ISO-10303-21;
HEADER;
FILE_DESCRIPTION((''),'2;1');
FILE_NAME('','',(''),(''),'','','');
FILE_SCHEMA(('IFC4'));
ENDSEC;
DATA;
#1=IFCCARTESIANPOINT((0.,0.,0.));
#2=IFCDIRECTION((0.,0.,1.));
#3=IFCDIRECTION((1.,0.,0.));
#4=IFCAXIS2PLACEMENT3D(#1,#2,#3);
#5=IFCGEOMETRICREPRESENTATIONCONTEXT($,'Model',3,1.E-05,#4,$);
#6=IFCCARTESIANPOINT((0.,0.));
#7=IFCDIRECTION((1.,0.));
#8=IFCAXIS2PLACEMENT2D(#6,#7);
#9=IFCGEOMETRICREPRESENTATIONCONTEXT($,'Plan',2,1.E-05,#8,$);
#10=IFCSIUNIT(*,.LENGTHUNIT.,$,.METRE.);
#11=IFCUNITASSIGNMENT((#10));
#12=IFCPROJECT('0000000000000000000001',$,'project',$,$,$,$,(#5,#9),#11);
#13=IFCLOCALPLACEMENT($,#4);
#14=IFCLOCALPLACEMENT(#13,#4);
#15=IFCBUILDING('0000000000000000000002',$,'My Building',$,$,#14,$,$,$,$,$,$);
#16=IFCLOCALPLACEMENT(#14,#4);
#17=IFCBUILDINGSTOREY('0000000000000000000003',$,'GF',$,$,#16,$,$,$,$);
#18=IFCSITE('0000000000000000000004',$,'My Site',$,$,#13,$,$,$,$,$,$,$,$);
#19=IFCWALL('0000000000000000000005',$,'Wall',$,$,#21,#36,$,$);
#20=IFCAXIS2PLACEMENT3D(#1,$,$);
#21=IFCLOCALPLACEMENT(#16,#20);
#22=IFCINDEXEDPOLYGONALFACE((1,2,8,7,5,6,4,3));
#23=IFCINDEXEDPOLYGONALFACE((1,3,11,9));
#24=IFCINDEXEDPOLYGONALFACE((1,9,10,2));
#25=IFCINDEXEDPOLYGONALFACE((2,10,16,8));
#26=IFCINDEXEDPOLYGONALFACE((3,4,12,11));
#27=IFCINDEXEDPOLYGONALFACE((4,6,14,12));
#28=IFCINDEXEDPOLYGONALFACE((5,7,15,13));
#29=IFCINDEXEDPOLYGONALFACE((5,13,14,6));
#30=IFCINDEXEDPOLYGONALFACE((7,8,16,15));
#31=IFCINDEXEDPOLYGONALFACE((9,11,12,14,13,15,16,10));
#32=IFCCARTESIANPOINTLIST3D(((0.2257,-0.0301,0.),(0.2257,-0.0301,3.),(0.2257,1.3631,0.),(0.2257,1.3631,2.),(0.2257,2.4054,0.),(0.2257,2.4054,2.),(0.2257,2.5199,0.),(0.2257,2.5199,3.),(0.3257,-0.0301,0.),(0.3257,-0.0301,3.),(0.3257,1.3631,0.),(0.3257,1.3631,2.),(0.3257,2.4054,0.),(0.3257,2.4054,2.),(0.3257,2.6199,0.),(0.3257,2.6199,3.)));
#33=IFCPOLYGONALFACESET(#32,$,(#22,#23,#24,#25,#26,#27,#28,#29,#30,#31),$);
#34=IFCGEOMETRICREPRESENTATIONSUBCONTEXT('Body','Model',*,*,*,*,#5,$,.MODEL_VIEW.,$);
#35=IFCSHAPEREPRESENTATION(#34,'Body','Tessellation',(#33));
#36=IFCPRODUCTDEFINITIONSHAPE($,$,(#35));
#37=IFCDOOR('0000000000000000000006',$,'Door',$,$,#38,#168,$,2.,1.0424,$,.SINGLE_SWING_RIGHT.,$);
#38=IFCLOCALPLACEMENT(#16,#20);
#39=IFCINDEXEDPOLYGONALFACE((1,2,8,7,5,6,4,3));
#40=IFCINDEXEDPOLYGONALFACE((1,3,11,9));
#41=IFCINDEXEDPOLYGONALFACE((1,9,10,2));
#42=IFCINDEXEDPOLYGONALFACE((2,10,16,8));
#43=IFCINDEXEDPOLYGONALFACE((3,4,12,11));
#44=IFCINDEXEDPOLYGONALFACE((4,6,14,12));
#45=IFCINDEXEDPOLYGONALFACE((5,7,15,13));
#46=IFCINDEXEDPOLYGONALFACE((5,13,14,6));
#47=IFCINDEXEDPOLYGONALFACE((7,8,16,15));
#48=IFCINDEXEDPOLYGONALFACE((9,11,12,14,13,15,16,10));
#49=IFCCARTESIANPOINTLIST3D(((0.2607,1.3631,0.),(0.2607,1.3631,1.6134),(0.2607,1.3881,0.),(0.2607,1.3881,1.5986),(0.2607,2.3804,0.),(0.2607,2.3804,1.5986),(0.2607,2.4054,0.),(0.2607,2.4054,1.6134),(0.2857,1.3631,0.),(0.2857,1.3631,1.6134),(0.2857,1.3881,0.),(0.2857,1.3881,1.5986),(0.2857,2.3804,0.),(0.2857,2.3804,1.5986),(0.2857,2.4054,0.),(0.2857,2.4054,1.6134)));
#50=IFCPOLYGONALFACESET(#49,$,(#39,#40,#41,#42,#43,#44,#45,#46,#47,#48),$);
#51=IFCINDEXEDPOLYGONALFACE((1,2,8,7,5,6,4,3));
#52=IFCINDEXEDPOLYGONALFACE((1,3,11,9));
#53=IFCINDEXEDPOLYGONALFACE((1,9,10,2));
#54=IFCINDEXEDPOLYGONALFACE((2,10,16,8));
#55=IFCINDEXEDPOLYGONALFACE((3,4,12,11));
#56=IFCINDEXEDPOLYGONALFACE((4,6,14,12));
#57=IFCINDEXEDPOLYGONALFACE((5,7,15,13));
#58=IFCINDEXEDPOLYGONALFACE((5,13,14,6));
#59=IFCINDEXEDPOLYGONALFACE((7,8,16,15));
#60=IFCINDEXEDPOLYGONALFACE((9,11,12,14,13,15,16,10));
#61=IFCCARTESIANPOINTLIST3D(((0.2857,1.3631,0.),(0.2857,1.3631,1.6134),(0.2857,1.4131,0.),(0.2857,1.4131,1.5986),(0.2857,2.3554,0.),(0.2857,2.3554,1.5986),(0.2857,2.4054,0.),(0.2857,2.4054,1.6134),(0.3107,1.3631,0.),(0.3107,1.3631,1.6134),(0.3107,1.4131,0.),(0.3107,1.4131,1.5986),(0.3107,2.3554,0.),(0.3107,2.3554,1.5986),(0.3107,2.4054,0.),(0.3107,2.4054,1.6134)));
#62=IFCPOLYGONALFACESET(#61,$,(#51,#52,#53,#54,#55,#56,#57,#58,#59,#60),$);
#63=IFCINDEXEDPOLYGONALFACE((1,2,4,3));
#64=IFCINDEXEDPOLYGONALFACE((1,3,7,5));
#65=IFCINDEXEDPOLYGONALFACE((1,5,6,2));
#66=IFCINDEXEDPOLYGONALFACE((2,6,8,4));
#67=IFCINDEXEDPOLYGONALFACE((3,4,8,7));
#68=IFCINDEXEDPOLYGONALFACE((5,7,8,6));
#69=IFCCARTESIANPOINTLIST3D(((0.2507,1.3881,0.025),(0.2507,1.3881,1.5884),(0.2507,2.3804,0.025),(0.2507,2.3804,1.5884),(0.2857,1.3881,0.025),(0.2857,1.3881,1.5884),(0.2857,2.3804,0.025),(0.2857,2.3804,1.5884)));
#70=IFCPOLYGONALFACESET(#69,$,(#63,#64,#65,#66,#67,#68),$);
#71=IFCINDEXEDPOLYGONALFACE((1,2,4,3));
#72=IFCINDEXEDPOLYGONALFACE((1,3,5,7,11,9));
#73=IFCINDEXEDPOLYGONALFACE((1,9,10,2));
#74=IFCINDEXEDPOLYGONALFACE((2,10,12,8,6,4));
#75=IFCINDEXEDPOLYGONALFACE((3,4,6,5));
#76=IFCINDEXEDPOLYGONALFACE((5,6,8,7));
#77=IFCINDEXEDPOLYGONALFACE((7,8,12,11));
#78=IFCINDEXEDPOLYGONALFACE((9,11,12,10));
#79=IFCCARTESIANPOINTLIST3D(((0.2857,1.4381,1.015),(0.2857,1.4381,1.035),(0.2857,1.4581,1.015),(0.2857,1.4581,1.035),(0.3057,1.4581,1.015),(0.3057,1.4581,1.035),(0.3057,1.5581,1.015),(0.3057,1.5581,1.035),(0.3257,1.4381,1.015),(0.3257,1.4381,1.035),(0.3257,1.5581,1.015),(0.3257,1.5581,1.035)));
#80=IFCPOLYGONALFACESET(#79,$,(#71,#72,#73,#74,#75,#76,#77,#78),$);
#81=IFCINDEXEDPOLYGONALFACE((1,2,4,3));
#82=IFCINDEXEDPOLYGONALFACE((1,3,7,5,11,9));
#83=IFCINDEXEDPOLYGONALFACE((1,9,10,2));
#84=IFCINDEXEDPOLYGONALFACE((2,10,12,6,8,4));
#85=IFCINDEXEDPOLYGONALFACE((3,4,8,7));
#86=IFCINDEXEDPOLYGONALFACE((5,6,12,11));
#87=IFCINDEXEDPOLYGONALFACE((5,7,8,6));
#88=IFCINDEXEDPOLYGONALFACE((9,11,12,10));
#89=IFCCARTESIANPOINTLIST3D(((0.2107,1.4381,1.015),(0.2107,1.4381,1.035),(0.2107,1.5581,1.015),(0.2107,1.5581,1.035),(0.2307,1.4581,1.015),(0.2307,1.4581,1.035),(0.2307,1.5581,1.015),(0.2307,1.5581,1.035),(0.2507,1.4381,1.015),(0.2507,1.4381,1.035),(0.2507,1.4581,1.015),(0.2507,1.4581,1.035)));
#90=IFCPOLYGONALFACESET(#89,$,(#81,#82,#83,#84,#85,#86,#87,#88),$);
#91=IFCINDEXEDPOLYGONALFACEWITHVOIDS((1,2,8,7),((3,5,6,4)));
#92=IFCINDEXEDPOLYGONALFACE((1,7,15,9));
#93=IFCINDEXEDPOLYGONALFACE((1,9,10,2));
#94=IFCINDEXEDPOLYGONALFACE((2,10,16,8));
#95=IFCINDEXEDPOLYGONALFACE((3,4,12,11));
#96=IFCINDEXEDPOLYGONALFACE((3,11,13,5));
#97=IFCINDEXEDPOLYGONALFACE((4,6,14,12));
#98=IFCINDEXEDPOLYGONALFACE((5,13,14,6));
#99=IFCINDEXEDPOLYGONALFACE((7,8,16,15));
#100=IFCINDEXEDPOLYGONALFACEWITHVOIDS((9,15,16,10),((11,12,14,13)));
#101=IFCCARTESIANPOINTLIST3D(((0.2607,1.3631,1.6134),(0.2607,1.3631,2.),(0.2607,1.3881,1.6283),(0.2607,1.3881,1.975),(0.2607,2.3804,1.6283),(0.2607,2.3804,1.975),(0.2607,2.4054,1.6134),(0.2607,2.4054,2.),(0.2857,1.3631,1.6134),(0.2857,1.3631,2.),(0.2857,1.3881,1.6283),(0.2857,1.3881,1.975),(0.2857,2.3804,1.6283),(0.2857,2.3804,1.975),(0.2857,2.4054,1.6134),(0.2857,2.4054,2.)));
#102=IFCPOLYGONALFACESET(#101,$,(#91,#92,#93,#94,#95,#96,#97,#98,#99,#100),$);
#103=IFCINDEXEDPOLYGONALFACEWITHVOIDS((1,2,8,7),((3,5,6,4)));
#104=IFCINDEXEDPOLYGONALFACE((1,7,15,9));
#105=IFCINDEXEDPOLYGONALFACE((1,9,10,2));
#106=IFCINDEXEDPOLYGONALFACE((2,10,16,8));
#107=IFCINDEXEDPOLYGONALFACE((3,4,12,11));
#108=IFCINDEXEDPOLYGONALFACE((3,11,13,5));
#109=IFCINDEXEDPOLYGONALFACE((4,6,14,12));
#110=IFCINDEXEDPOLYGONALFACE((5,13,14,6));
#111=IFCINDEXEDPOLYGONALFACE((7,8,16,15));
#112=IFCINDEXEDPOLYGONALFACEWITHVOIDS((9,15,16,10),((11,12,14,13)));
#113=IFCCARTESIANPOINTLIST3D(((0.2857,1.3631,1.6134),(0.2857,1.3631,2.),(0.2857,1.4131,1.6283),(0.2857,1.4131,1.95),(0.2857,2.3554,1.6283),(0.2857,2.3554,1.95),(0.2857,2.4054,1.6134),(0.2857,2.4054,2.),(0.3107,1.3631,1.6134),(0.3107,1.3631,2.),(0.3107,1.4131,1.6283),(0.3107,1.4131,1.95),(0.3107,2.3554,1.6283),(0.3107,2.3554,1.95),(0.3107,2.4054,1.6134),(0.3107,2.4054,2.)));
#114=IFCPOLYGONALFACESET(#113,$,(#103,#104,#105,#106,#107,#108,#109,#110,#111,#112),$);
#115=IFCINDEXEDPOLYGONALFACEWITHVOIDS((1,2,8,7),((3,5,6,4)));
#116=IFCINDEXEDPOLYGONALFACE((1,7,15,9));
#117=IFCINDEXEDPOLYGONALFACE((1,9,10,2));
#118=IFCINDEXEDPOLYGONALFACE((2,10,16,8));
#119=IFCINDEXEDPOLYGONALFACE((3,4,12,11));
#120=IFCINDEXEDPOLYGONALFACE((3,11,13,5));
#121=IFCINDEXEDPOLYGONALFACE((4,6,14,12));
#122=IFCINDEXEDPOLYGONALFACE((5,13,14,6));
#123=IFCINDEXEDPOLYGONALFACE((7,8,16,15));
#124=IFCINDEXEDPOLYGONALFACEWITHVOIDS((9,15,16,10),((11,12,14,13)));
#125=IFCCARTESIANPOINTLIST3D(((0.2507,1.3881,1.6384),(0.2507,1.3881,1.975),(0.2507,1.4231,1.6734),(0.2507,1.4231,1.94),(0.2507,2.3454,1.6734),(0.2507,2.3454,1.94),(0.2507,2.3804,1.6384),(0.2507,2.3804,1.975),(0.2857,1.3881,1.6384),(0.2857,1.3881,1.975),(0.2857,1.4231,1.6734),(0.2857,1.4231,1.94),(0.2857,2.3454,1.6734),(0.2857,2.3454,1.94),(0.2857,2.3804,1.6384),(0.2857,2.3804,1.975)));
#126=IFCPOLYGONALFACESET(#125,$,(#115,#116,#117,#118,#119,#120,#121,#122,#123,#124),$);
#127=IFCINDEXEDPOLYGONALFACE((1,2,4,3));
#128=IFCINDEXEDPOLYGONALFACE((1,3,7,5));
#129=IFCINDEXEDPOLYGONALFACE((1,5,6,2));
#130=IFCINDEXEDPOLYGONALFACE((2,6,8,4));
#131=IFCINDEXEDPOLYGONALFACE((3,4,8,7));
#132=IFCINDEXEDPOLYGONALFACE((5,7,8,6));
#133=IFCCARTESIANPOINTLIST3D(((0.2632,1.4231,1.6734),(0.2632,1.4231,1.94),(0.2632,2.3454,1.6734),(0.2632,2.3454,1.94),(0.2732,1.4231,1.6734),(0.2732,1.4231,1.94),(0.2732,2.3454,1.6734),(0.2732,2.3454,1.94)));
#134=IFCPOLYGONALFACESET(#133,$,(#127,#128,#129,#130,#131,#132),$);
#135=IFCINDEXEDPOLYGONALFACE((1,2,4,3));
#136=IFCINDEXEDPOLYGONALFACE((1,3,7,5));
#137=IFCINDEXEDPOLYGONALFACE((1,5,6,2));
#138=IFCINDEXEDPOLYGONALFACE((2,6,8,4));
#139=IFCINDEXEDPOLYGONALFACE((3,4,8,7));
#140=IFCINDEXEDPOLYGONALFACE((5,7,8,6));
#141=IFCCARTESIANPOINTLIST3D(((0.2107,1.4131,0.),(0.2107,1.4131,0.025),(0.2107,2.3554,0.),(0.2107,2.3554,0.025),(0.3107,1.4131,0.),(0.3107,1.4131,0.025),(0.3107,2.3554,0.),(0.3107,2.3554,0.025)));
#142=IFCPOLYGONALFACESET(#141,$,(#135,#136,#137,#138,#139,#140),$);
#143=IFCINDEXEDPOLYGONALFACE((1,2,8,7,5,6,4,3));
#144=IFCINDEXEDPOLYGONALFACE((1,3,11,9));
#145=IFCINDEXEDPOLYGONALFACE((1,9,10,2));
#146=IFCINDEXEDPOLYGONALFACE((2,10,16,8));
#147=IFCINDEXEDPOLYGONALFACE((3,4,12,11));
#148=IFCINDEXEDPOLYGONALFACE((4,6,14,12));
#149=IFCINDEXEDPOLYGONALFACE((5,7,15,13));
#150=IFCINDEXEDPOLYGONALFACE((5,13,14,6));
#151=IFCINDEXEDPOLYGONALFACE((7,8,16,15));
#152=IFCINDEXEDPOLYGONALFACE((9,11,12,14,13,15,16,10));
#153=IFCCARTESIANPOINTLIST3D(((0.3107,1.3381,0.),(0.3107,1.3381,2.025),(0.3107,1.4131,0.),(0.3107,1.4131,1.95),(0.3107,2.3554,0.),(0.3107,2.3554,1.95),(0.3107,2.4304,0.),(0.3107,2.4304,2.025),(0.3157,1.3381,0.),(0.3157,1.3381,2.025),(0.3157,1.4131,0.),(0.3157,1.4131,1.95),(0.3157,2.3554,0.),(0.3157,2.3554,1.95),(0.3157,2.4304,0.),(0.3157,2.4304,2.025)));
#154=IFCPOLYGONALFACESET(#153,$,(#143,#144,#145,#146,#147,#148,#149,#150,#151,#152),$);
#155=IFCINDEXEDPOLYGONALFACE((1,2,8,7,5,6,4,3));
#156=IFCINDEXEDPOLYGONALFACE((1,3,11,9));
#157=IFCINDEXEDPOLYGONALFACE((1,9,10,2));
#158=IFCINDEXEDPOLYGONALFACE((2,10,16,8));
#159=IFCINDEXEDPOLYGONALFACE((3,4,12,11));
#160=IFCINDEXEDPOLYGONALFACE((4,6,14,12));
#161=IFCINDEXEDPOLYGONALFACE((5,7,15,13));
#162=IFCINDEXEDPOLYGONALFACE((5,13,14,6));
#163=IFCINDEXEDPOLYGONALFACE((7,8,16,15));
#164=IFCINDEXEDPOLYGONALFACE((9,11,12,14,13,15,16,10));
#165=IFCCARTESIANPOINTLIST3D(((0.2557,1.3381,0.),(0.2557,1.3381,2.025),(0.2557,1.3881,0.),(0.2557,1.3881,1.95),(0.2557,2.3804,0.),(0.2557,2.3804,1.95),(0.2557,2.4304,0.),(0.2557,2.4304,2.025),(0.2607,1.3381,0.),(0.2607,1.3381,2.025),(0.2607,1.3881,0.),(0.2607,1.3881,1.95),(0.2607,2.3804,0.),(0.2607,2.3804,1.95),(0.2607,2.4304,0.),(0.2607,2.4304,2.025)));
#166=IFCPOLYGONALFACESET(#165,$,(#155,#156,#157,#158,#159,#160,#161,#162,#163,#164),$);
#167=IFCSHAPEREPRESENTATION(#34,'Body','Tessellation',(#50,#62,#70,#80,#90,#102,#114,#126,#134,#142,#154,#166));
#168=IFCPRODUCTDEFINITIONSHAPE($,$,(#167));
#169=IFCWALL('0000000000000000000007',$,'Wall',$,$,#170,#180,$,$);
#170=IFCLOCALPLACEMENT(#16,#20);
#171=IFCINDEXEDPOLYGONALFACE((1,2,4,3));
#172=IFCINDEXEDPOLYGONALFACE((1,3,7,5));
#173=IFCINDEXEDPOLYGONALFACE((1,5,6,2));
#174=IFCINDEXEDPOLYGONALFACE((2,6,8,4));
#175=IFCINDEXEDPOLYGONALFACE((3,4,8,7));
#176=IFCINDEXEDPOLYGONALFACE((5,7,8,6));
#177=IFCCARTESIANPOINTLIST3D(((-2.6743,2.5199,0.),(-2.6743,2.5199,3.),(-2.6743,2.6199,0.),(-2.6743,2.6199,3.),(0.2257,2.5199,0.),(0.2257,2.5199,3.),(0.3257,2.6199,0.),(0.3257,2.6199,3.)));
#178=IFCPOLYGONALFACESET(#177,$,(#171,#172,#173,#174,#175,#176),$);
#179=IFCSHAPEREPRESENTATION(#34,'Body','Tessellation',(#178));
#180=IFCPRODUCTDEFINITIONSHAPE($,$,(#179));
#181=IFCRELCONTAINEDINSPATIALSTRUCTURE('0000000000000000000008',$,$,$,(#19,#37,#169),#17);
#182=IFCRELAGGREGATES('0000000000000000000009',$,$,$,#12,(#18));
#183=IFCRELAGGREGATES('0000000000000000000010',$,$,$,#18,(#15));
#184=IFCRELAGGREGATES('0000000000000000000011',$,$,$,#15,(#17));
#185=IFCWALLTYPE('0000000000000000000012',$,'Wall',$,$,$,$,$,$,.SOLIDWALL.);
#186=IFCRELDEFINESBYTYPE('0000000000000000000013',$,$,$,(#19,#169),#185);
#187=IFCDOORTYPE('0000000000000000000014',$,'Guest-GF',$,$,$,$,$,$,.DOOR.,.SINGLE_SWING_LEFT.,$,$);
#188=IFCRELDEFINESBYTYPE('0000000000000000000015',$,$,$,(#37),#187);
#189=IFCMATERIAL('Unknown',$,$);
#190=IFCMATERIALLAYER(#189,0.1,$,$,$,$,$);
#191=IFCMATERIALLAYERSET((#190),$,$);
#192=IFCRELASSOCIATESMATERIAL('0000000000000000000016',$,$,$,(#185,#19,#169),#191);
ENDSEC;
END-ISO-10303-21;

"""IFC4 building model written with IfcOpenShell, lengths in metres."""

from ifc_helpers import new_model, entity, si_unit, frame, origin_with_axes, origin_2d_with_axis, place, context, subcontext, project, spatial, line, indexed_curve, outline, extrude, shape, source, transform, mapped, material, layer, layer_set, layer_usage, type_object, type_shapes, element, fill, save


model = new_model("IFC4")

# Units and contexts
model_context = context("Model", 3, precision=1e-05, world=origin_with_axes())
plan_context = context("Plan", 2, precision=1e-05, world=origin_2d_with_axis())
body_context_1 = subcontext(model_context, "Body", "Model", "MODEL_VIEW")
body_context_2 = subcontext(plan_context, "Body", "Plan", "PLAN_VIEW")
ifc_project = project(units=[si_unit("LENGTHUNIT", "METRE")], contexts=[model_context, plan_context])

# Site, building, storey
site_placement = place(None, origin_with_axes())
site = spatial("IfcSite", under=ifc_project, at=site_placement, Name="My Site")
building_placement = place(site_placement, origin_with_axes())
building = spatial("IfcBuilding", under=site, at=building_placement, Name="My Building")
storey_placement = place(building_placement, origin_with_axes())
storey = spatial("IfcBuildingStorey", under=building, at=storey_placement, Name="GF")

# Shared definitions
ifc_material_1 = material(Name="Unknown")

# Shared definitions
ifc_layer_1 = layer(ifc_material_1, 0.1)
ifc_layer_set_1 = layer_set([ifc_layer_1])
wall_type = type_object("IfcWallType", Name="Wall", PredefinedType="SOLIDWALL", material=ifc_layer_set_1)

# Wall, opening, door
ifc_layer_usage_1 = layer_usage(ifc_layer_set_1, "AXIS2", "POSITIVE", 0.0)
wall_1_placement = place(storey_placement, frame((0.3257, -0.0301, 0.0), z_axis=(0.0, 0.0, 1.0), x_axis=(0.0, 1.0, 0.0)))
wall_1 = element("IfcWall", 1, at=wall_1_placement, inside=storey, type_object=wall_type, material=ifc_layer_usage_1, Name="Wall", context=body_context_1, shape_type="SweptSolid", body=[
    extrude(outline(indexed_curve([(0.0, 0.0), (0.0, 0.1), (2.55, 0.1), (2.65, 0.0)], segments=[line(1, 2, 3, 4, 1)])), origin_with_axes(), (0.0, 0.0, 1.0), 3.0),
])
shared_shape_1 = source(origin_with_axes(), body_context_1, "Body", "SweptSolid", [
    extrude(outline(indexed_curve([(0.0, 0.0), (1.0424, 0.0), (1.0424, 2.0), (0.0, 2.0)], segments=[line(1, 2, 3, 4, 1)])), frame((0.0, -0.6, 0.0), z_axis=(0.0, -1.0, 0.0), x_axis=(1.0, 0.0, 0.0)), (0.0, 0.0, -1.0), 1.2),
])
opening_1_placement = place(wall_1_placement, frame((1.3932, 0.015, 0.0), z_axis=(0.0, 0.0, 1.0), x_axis=(1.0, 0.0, 0.0)))
opening_1 = element("IfcOpeningElement", 2, at=opening_1_placement, cuts=wall_1, PredefinedType="OPENING", context=body_context_1, shape_type="MappedRepresentation", body=[
    mapped(shared_shape_1, transform((0.0, 0.0, 0.0), x_axis=(1.0, 0.0, 0.0), y_axis=(0.0, 1.0, 0.0), z_axis=(0.0, 0.0, 1.0), scale=1.0)),
])
door_type_1 = type_object("IfcDoorType", Name="Guest-GF", OperationType="SINGLE_SWING_LEFT", PredefinedType="DOOR")
shared_shape_2 = source(origin_with_axes(), body_context_1, "Body", "SweptSolid", [
    extrude(outline(indexed_curve([(0.0, 0.0), (0.0, 1.6134), (1.0424, 1.6134), (1.0424, 0.0), (1.0174, 0.0), (1.0174, 1.5986), (0.025, 1.5986), (0.025, 0.0)], segments=[line(1, 2, 3, 4, 5, 6, 7, 8, 1)])), frame((0.0, 0.025, 0.0), z_axis=(0.0, -1.0, 0.0), x_axis=(1.0, 0.0, 0.0)), (0.0, 0.0, -1.0), 0.025),
    extrude(outline(indexed_curve([(0.0, 0.0), (0.0, 1.6134), (1.0424, 1.6134), (1.0424, 0.0), (0.9924, 0.0), (0.9924, 1.5986), (0.05, 1.5986), (0.05, 0.0)], segments=[line(1, 2, 3, 4, 5, 6, 7, 8, 1)])), frame((0.0, 0.0, 0.0), z_axis=(0.0, -1.0, 0.0), x_axis=(1.0, 0.0, 0.0)), (0.0, 0.0, -1.0), 0.025),
    extrude(outline(indexed_curve([(0.0, 0.0), (0.9924, 0.0), (0.9924, 0.035), (0.0, 0.035)], segments=[line(1, 2, 3, 4, 1)])), frame((0.025, 0.025, 0.025), z_axis=(0.0, 0.0, 1.0), x_axis=(1.0, 0.0, 0.0)), (0.0, 0.0, 1.0), 1.5634),
    extrude(outline(indexed_curve([(0.0, 0.0), (0.0, -0.04), (0.12, -0.04), (0.12, -0.02), (0.02, -0.02), (0.02, 0.0)], segments=[line(1, 2, 3, 4, 5, 6, 1)])), frame((0.075, 0.025, 1.015), z_axis=(0.0, 0.0, 1.0), x_axis=(1.0, 0.0, 0.0)), (0.0, 0.0, 1.0), 0.02),
    extrude(outline(indexed_curve([(0.0, 0.0), (0.0, 0.04), (0.12, 0.04), (0.12, 0.02), (0.02, 0.02), (0.02, 0.0)], segments=[line(1, 2, 3, 4, 5, 6, 1)])), frame((0.075, 0.06, 1.015), z_axis=(0.0, 0.0, 1.0), x_axis=(1.0, 0.0, 0.0)), (0.0, 0.0, 1.0), 0.02),
    extrude(outline(indexed_curve([(0.0, 0.0), (1.0424, 0.0), (1.0424, 0.3866), (0.0, 0.3866)], segments=[line(1, 2, 3, 4, 1)]), holes=[indexed_curve([(0.025, 0.0148), (1.0174, 0.0148), (1.0174, 0.3616), (0.025, 0.3616)], segments=[line(1, 2, 3, 4, 1)])]), frame((0.0, 0.025, 1.6134), z_axis=(0.0, -1.0, 0.0), x_axis=(1.0, 0.0, 0.0)), (0.0, 0.0, -1.0), 0.025),
    extrude(outline(indexed_curve([(0.0, 0.0), (1.0424, 0.0), (1.0424, 0.3866), (0.0, 0.3866)], segments=[line(1, 2, 3, 4, 1)]), holes=[indexed_curve([(0.05, 0.0148), (0.9924, 0.0148), (0.9924, 0.3366), (0.05, 0.3366)], segments=[line(1, 2, 3, 4, 1)])]), frame((0.0, 0.0, 1.6134), z_axis=(0.0, -1.0, 0.0), x_axis=(1.0, 0.0, 0.0)), (0.0, 0.0, -1.0), 0.025),
    extrude(outline(indexed_curve([(0.0, 0.0), (0.9924, 0.0), (0.9924, 0.3366), (0.0, 0.3366)], segments=[line(1, 2, 3, 4, 1)]), holes=[indexed_curve([(0.035, 0.035), (0.9574, 0.035), (0.9574, 0.3016), (0.035, 0.3016)], segments=[line(1, 2, 3, 4, 1)])]), frame((0.025, 0.025, 1.6384), z_axis=(0.0, -1.0, 0.0), x_axis=(1.0, 0.0, 0.0)), (0.0, 0.0, -1.0), 0.035),
    extrude(outline(indexed_curve([(0.035, 0.035), (0.9574, 0.035), (0.9574, 0.3016), (0.035, 0.3016)], segments=[line(1, 2, 3, 4, 1)])), frame((0.025, 0.0375, 1.6384), z_axis=(0.0, -1.0, 0.0), x_axis=(1.0, 0.0, 0.0)), (0.0, 0.0, -1.0), 0.01),
    extrude(outline(indexed_curve([(0.0, 0.0), (0.9424, 0.0), (0.9424, 0.1), (0.0, 0.1)], segments=[line(1, 2, 3, 4, 1)])), frame((0.05, 0.0, 0.0), z_axis=(0.0, 0.0, 1.0), x_axis=(1.0, 0.0, 0.0)), (0.0, 0.0, 1.0), 0.025),
    extrude(outline(indexed_curve([(0.0, 0.0), (0.0, 2.025), (1.0924, 2.025), (1.0924, 0.0), (1.0174, 0.0), (1.0174, 1.95), (0.075, 1.95), (0.075, 0.0)], segments=[line(1, 2, 3, 4, 5, 6, 7, 8, 1)])), frame((-0.025, -0.005, 0.0), z_axis=(0.0, -1.0, 0.0), x_axis=(1.0, 0.0, 0.0)), (0.0, 0.0, -1.0), 0.005),
    extrude(outline(indexed_curve([(0.0, 0.0), (0.0, 2.025), (1.0924, 2.025), (1.0924, 0.0), (1.0424, 0.0), (1.0424, 1.95), (0.05, 1.95), (0.05, 0.0)], segments=[line(1, 2, 3, 4, 5, 6, 7, 8, 1)])), frame((-0.025, 0.05, 0.0), z_axis=(0.0, -1.0, 0.0), x_axis=(1.0, 0.0, 0.0)), (0.0, 0.0, -1.0), 0.005),
])
shared_shape_3 = source(origin_with_axes(), body_context_2, "Body", "Curve2D", [
    entity("IfcIndexedPolyCurve", entity("IfcCartesianPointList2D", [[0.0, 0.0], [0.0, 0.05], [0.025, 0.05], [0.025, 0.025], [0.05, 0.025], [0.05, 0.0]]), [entity("IfcLineIndex", [1, 2, 3, 4, 5, 6, 1])]),
    entity("IfcIndexedPolyCurve", entity("IfcCartesianPointList2D", [[1.0424, 0.0], [1.0424, 0.05], [1.0174, 0.05], [1.0174, 0.025], [0.9924, 0.025], [0.9924, 0.0]]), [entity("IfcLineIndex", [1, 2, 3, 4, 5, 6, 1])]),
    entity("IfcTrimmedCurve", entity("IfcEllipse", entity("IfcAxis2Placement2D", entity("IfcCartesianPoint", [0.9824, 0.05]), entity("IfcDirection", [1.0, 0.0])), 0.9574, 0.9924), [entity("IfcCartesianPoint", [0.9824, 1.0424])], [entity("IfcCartesianPoint", [0.025, 0.05])], True, "CARTESIAN"),
    entity("IfcIndexedPolyCurve", entity("IfcCartesianPointList2D", [[1.0174, 0.05], [0.9824, 0.05], [0.9824, 1.0424], [1.0174, 1.0424]]), [entity("IfcLineIndex", [1, 2, 3, 4, 1])]),
])
type_shapes(door_type_1, [shared_shape_2, shared_shape_3])
door_1_placement = place(opening_1_placement, frame((0.0, 0.0, 0.0), z_axis=(0.0, 0.0, 1.0), x_axis=(1.0, 0.0, 0.0)))
door_1 = element("IfcDoor", 3, at=door_1_placement, inside=storey, type_object=door_type_1, Name="Door", OperationType="SINGLE_SWING_RIGHT", OverallHeight=2.0, OverallWidth=1.0424, shapes=[
    shape(body_context_1, "Body", "MappedRepresentation", [mapped(shared_shape_2, transform((0.0, 0.0, 0.0), x_axis=(1.0, 0.0, 0.0), y_axis=(0.0, 1.0, 0.0), z_axis=(0.0, 0.0, 1.0), scale=1.0))]),
    shape(body_context_2, "Body", "MappedRepresentation", [mapped(shared_shape_3, transform((0.0, 0.0, 0.0), x_axis=(1.0, 0.0, 0.0), y_axis=(0.0, 1.0, 0.0), z_axis=(0.0, 0.0, 1.0), scale=1.0))]),
])
fill(opening_1, door_1)

# Wall
ifc_layer_usage_2 = layer_usage(ifc_layer_set_1, "AXIS2", "POSITIVE", 0.0)
wall_2_placement = place(storey_placement, frame((0.3257, 2.6199, 0.0), z_axis=(0.0, 0.0, 1.0), x_axis=(-1.0, 0.0, 0.0)))
element("IfcWall", 4, at=wall_2_placement, inside=storey, type_object=wall_type, material=ifc_layer_usage_2, Name="Wall", context=body_context_1, shape_type="SweptSolid", body=[
    extrude(outline(indexed_curve([(0.0, 0.0), (0.1, 0.1), (3.0, 0.1), (3.0, 0.0)], segments=[line(1, 2, 3, 4, 1)])), origin_with_axes(), (0.0, 0.0, 1.0), 3.0),
])

save(model, "model.ifc")
